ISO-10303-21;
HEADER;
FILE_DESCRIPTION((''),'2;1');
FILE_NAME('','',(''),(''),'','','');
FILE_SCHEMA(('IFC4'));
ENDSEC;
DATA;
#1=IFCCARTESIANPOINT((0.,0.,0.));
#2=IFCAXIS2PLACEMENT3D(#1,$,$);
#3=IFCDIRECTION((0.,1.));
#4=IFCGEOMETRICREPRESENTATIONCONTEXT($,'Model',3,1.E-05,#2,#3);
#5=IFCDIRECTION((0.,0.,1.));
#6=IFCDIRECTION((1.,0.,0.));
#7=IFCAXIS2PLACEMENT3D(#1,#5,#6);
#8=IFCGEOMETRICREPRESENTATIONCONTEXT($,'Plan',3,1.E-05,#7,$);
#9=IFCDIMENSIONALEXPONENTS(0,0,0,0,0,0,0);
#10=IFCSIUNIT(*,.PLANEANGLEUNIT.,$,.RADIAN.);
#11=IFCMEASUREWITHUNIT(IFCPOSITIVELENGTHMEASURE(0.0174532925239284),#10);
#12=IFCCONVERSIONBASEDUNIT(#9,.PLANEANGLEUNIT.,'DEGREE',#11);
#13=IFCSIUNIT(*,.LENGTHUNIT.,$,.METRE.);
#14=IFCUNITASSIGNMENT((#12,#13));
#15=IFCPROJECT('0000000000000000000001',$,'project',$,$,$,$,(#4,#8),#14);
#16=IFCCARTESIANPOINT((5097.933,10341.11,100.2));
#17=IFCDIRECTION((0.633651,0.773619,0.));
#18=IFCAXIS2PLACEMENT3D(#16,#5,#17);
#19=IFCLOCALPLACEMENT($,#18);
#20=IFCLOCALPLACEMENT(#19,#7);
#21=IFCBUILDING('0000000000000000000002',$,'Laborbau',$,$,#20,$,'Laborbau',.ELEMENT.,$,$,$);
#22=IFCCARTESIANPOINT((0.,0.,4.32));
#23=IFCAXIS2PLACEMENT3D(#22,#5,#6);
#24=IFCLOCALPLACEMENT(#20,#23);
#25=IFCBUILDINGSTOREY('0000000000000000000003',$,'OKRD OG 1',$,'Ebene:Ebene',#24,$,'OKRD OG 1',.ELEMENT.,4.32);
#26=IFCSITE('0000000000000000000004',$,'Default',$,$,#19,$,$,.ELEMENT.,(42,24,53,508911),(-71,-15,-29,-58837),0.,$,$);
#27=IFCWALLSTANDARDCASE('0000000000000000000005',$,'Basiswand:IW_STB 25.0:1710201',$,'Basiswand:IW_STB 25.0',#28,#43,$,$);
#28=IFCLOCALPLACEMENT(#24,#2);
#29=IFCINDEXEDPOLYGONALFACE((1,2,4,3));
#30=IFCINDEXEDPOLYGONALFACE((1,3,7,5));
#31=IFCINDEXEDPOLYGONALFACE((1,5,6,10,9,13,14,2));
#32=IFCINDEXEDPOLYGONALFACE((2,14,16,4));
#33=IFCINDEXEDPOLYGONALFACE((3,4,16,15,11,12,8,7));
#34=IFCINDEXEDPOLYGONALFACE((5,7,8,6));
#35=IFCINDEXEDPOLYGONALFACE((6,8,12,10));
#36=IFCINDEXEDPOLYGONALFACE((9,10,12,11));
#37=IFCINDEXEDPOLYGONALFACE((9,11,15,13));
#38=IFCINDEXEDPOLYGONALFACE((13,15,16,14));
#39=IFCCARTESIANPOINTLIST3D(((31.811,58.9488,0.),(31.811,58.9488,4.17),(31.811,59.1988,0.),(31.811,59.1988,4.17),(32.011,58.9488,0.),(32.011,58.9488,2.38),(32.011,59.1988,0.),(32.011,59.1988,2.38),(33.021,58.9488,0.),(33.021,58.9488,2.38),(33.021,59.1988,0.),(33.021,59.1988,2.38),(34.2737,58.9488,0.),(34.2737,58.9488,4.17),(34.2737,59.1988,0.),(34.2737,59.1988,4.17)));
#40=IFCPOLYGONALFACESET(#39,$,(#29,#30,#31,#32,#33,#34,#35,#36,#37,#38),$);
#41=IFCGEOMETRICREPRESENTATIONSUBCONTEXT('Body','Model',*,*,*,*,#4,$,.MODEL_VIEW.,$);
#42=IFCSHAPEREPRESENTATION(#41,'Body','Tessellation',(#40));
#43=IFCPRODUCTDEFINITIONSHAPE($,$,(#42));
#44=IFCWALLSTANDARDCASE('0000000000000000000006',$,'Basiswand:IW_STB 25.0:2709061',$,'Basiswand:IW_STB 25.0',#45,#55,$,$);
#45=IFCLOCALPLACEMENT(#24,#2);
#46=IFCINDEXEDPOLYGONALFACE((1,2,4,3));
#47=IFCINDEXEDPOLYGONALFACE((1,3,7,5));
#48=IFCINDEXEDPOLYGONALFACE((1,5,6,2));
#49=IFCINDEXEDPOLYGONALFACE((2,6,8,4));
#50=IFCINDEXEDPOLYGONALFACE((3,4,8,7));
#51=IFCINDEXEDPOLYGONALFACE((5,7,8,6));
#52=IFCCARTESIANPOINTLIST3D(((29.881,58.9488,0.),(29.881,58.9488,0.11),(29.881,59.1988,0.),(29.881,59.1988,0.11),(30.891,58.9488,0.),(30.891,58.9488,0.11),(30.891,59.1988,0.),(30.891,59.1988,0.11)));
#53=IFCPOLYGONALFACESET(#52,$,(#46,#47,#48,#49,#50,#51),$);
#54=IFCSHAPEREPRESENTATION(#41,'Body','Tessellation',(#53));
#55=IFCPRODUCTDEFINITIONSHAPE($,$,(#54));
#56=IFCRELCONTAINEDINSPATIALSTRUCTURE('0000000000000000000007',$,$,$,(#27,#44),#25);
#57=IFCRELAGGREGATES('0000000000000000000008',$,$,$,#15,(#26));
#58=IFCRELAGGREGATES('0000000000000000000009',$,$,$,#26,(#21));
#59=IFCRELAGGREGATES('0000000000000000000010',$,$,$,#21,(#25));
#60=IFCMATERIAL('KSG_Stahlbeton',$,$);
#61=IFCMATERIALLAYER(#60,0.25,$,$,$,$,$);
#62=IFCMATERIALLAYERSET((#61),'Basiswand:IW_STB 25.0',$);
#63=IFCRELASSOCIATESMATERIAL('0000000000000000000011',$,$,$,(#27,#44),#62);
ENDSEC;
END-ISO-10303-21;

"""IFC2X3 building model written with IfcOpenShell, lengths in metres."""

from ifc_helpers import new_model, entity, si_unit, converted_unit, direction, frame, frame_2d, origin, origin_with_axes, place, context, subcontext, project, spatial, rectangle, extrude, material, layer, layer_set, layer_usage, element, save


model = new_model("IFC2X3")

# Units and contexts
model_context = context("Model", 3, precision=1e-05, world=origin(), true_north=direction((0.0, 1.0)))
plan_context = context("Plan", 3, precision=1e-05, world=origin_with_axes())
body_context = subcontext(model_context, "Body", "Model", "MODEL_VIEW")
ifc_project = project(units=[converted_unit("PLANEANGLEUNIT", "DEGREE", entity("IfcPositiveLengthMeasure", 0.0174532925239284), si_unit("PLANEANGLEUNIT", "RADIAN"), dimensions=[0, 0, 0, 0, 0, 0, 0]), si_unit("LENGTHUNIT", "METRE")], contexts=[model_context, plan_context])

# Site, building, storey
site_placement = place(None, frame((5097.933, 10341.11, 100.2), z_axis=(0.0, 0.0, 1.0), x_axis=(0.633651, 0.773619, 0.0)))
site = spatial("IfcSite", under=ifc_project, at=site_placement, Name="Default", CompositionType="ELEMENT", RefLatitude=(42, 24, 53, 508911), RefLongitude=(-71, -15, -29, -58837), RefElevation=0.0)
building_placement = place(site_placement, origin_with_axes())
building = spatial("IfcBuilding", under=site, at=building_placement, Name="Laborbau", LongName="Laborbau", CompositionType="ELEMENT")
storey_placement = place(building_placement, frame((0.0, 0.0, 4.32), z_axis=(0.0, 0.0, 1.0), x_axis=(1.0, 0.0, 0.0)))
storey = spatial("IfcBuildingStorey", under=building, at=storey_placement, Name="OKRD OG 1", ObjectType="Ebene:Ebene", LongName="OKRD OG 1", CompositionType="ELEMENT", Elevation=4.32)

# Shared definitions
ifc_material_1 = material(Name="KSG_Stahlbeton")
ifc_layer_1 = layer(ifc_material_1, 0.25)
ifc_layer_set_1 = layer_set([ifc_layer_1], Name="Basiswand:IW_STB 25.0")

# Wall, openings
ifc_layer_usage_1 = layer_usage(ifc_layer_set_1, "AXIS2", "POSITIVE", -0.125)
wall_1_placement = place(storey_placement, frame((31.811, 59.0738, 0.0), z_axis=(0.0, 0.0, 1.0), x_axis=(1.0, 0.0, 0.0)))
wall_1 = element("IfcWallStandardCase", 1, at=wall_1_placement, inside=storey, material=ifc_layer_usage_1, Name="Basiswand:IW_STB 25.0:1710201", ObjectType="Basiswand:IW_STB 25.0", context=body_context, shape_type="SweptSolid", body=[
    extrude(rectangle(XDim=2.4627, YDim=0.25, at=frame_2d((1.2313, 0.0), x_axis=(-1.0, 0.0))), origin(), (0.0, 0.0, 1.0), 4.17),
])
opening_1_placement = place(wall_1_placement, frame((-31.811, -59.0738, 0.0), z_axis=(0.0, 0.0, 1.0), x_axis=(1.0, 0.0, 0.0)))
element("IfcOpeningElement", 2, at=opening_1_placement, cuts=wall_1, ObjectType="Opening", context=body_context, shape_type="SweptSolid", body=[
    extrude(rectangle(XDim=2.38, YDim=1.01, at=frame_2d((0.0, 0.0), x_axis=(0.0, 1.0))), frame((32.516, 57.4248, 1.19), z_axis=(0.0, 1.0, 0.0), x_axis=(-1.0, 0.0, 0.0)), (0.0, 0.0, 1.0), 3.048),
])
opening_2_placement = place(wall_1_placement, frame((0.2, -0.125, 0.0), z_axis=(0.0, 0.0, 1.0), x_axis=(1.0, 0.0, 0.0)))
element("IfcOpeningElement", 3, at=opening_2_placement, cuts=wall_1, ObjectType="Opening", context=body_context, shape_type="SweptSolid", body=[
    extrude(rectangle(XDim=2.38, YDim=1.01, at=frame_2d((1.19, 0.505), x_axis=(1.0, 0.0))), frame((0.0, 0.0, 0.0), z_axis=(0.0, 1.0, 0.0), x_axis=(0.0, 0.0, 1.0)), (0.0, 0.0, 1.0), 0.25),
])

# Wall
ifc_layer_usage_2 = layer_usage(ifc_layer_set_1, "AXIS2", "NEGATIVE", 0.125)
wall_2_placement = place(storey_placement, frame((29.881, 59.0738, 0.0), z_axis=(0.0, 0.0, 1.0), x_axis=(1.0, 0.0, 0.0)))
element("IfcWallStandardCase", 4, at=wall_2_placement, inside=storey, material=ifc_layer_usage_2, Name="Basiswand:IW_STB 25.0:2709061", ObjectType="Basiswand:IW_STB 25.0", context=body_context, shape_type="SweptSolid", body=[
    extrude(rectangle(XDim=1.01, YDim=0.25, at=frame_2d((0.505, 0.0), x_axis=(-1.0, 0.0))), origin(), (0.0, 0.0, 1.0), 0.11),
])

save(model, "model.ifc")
